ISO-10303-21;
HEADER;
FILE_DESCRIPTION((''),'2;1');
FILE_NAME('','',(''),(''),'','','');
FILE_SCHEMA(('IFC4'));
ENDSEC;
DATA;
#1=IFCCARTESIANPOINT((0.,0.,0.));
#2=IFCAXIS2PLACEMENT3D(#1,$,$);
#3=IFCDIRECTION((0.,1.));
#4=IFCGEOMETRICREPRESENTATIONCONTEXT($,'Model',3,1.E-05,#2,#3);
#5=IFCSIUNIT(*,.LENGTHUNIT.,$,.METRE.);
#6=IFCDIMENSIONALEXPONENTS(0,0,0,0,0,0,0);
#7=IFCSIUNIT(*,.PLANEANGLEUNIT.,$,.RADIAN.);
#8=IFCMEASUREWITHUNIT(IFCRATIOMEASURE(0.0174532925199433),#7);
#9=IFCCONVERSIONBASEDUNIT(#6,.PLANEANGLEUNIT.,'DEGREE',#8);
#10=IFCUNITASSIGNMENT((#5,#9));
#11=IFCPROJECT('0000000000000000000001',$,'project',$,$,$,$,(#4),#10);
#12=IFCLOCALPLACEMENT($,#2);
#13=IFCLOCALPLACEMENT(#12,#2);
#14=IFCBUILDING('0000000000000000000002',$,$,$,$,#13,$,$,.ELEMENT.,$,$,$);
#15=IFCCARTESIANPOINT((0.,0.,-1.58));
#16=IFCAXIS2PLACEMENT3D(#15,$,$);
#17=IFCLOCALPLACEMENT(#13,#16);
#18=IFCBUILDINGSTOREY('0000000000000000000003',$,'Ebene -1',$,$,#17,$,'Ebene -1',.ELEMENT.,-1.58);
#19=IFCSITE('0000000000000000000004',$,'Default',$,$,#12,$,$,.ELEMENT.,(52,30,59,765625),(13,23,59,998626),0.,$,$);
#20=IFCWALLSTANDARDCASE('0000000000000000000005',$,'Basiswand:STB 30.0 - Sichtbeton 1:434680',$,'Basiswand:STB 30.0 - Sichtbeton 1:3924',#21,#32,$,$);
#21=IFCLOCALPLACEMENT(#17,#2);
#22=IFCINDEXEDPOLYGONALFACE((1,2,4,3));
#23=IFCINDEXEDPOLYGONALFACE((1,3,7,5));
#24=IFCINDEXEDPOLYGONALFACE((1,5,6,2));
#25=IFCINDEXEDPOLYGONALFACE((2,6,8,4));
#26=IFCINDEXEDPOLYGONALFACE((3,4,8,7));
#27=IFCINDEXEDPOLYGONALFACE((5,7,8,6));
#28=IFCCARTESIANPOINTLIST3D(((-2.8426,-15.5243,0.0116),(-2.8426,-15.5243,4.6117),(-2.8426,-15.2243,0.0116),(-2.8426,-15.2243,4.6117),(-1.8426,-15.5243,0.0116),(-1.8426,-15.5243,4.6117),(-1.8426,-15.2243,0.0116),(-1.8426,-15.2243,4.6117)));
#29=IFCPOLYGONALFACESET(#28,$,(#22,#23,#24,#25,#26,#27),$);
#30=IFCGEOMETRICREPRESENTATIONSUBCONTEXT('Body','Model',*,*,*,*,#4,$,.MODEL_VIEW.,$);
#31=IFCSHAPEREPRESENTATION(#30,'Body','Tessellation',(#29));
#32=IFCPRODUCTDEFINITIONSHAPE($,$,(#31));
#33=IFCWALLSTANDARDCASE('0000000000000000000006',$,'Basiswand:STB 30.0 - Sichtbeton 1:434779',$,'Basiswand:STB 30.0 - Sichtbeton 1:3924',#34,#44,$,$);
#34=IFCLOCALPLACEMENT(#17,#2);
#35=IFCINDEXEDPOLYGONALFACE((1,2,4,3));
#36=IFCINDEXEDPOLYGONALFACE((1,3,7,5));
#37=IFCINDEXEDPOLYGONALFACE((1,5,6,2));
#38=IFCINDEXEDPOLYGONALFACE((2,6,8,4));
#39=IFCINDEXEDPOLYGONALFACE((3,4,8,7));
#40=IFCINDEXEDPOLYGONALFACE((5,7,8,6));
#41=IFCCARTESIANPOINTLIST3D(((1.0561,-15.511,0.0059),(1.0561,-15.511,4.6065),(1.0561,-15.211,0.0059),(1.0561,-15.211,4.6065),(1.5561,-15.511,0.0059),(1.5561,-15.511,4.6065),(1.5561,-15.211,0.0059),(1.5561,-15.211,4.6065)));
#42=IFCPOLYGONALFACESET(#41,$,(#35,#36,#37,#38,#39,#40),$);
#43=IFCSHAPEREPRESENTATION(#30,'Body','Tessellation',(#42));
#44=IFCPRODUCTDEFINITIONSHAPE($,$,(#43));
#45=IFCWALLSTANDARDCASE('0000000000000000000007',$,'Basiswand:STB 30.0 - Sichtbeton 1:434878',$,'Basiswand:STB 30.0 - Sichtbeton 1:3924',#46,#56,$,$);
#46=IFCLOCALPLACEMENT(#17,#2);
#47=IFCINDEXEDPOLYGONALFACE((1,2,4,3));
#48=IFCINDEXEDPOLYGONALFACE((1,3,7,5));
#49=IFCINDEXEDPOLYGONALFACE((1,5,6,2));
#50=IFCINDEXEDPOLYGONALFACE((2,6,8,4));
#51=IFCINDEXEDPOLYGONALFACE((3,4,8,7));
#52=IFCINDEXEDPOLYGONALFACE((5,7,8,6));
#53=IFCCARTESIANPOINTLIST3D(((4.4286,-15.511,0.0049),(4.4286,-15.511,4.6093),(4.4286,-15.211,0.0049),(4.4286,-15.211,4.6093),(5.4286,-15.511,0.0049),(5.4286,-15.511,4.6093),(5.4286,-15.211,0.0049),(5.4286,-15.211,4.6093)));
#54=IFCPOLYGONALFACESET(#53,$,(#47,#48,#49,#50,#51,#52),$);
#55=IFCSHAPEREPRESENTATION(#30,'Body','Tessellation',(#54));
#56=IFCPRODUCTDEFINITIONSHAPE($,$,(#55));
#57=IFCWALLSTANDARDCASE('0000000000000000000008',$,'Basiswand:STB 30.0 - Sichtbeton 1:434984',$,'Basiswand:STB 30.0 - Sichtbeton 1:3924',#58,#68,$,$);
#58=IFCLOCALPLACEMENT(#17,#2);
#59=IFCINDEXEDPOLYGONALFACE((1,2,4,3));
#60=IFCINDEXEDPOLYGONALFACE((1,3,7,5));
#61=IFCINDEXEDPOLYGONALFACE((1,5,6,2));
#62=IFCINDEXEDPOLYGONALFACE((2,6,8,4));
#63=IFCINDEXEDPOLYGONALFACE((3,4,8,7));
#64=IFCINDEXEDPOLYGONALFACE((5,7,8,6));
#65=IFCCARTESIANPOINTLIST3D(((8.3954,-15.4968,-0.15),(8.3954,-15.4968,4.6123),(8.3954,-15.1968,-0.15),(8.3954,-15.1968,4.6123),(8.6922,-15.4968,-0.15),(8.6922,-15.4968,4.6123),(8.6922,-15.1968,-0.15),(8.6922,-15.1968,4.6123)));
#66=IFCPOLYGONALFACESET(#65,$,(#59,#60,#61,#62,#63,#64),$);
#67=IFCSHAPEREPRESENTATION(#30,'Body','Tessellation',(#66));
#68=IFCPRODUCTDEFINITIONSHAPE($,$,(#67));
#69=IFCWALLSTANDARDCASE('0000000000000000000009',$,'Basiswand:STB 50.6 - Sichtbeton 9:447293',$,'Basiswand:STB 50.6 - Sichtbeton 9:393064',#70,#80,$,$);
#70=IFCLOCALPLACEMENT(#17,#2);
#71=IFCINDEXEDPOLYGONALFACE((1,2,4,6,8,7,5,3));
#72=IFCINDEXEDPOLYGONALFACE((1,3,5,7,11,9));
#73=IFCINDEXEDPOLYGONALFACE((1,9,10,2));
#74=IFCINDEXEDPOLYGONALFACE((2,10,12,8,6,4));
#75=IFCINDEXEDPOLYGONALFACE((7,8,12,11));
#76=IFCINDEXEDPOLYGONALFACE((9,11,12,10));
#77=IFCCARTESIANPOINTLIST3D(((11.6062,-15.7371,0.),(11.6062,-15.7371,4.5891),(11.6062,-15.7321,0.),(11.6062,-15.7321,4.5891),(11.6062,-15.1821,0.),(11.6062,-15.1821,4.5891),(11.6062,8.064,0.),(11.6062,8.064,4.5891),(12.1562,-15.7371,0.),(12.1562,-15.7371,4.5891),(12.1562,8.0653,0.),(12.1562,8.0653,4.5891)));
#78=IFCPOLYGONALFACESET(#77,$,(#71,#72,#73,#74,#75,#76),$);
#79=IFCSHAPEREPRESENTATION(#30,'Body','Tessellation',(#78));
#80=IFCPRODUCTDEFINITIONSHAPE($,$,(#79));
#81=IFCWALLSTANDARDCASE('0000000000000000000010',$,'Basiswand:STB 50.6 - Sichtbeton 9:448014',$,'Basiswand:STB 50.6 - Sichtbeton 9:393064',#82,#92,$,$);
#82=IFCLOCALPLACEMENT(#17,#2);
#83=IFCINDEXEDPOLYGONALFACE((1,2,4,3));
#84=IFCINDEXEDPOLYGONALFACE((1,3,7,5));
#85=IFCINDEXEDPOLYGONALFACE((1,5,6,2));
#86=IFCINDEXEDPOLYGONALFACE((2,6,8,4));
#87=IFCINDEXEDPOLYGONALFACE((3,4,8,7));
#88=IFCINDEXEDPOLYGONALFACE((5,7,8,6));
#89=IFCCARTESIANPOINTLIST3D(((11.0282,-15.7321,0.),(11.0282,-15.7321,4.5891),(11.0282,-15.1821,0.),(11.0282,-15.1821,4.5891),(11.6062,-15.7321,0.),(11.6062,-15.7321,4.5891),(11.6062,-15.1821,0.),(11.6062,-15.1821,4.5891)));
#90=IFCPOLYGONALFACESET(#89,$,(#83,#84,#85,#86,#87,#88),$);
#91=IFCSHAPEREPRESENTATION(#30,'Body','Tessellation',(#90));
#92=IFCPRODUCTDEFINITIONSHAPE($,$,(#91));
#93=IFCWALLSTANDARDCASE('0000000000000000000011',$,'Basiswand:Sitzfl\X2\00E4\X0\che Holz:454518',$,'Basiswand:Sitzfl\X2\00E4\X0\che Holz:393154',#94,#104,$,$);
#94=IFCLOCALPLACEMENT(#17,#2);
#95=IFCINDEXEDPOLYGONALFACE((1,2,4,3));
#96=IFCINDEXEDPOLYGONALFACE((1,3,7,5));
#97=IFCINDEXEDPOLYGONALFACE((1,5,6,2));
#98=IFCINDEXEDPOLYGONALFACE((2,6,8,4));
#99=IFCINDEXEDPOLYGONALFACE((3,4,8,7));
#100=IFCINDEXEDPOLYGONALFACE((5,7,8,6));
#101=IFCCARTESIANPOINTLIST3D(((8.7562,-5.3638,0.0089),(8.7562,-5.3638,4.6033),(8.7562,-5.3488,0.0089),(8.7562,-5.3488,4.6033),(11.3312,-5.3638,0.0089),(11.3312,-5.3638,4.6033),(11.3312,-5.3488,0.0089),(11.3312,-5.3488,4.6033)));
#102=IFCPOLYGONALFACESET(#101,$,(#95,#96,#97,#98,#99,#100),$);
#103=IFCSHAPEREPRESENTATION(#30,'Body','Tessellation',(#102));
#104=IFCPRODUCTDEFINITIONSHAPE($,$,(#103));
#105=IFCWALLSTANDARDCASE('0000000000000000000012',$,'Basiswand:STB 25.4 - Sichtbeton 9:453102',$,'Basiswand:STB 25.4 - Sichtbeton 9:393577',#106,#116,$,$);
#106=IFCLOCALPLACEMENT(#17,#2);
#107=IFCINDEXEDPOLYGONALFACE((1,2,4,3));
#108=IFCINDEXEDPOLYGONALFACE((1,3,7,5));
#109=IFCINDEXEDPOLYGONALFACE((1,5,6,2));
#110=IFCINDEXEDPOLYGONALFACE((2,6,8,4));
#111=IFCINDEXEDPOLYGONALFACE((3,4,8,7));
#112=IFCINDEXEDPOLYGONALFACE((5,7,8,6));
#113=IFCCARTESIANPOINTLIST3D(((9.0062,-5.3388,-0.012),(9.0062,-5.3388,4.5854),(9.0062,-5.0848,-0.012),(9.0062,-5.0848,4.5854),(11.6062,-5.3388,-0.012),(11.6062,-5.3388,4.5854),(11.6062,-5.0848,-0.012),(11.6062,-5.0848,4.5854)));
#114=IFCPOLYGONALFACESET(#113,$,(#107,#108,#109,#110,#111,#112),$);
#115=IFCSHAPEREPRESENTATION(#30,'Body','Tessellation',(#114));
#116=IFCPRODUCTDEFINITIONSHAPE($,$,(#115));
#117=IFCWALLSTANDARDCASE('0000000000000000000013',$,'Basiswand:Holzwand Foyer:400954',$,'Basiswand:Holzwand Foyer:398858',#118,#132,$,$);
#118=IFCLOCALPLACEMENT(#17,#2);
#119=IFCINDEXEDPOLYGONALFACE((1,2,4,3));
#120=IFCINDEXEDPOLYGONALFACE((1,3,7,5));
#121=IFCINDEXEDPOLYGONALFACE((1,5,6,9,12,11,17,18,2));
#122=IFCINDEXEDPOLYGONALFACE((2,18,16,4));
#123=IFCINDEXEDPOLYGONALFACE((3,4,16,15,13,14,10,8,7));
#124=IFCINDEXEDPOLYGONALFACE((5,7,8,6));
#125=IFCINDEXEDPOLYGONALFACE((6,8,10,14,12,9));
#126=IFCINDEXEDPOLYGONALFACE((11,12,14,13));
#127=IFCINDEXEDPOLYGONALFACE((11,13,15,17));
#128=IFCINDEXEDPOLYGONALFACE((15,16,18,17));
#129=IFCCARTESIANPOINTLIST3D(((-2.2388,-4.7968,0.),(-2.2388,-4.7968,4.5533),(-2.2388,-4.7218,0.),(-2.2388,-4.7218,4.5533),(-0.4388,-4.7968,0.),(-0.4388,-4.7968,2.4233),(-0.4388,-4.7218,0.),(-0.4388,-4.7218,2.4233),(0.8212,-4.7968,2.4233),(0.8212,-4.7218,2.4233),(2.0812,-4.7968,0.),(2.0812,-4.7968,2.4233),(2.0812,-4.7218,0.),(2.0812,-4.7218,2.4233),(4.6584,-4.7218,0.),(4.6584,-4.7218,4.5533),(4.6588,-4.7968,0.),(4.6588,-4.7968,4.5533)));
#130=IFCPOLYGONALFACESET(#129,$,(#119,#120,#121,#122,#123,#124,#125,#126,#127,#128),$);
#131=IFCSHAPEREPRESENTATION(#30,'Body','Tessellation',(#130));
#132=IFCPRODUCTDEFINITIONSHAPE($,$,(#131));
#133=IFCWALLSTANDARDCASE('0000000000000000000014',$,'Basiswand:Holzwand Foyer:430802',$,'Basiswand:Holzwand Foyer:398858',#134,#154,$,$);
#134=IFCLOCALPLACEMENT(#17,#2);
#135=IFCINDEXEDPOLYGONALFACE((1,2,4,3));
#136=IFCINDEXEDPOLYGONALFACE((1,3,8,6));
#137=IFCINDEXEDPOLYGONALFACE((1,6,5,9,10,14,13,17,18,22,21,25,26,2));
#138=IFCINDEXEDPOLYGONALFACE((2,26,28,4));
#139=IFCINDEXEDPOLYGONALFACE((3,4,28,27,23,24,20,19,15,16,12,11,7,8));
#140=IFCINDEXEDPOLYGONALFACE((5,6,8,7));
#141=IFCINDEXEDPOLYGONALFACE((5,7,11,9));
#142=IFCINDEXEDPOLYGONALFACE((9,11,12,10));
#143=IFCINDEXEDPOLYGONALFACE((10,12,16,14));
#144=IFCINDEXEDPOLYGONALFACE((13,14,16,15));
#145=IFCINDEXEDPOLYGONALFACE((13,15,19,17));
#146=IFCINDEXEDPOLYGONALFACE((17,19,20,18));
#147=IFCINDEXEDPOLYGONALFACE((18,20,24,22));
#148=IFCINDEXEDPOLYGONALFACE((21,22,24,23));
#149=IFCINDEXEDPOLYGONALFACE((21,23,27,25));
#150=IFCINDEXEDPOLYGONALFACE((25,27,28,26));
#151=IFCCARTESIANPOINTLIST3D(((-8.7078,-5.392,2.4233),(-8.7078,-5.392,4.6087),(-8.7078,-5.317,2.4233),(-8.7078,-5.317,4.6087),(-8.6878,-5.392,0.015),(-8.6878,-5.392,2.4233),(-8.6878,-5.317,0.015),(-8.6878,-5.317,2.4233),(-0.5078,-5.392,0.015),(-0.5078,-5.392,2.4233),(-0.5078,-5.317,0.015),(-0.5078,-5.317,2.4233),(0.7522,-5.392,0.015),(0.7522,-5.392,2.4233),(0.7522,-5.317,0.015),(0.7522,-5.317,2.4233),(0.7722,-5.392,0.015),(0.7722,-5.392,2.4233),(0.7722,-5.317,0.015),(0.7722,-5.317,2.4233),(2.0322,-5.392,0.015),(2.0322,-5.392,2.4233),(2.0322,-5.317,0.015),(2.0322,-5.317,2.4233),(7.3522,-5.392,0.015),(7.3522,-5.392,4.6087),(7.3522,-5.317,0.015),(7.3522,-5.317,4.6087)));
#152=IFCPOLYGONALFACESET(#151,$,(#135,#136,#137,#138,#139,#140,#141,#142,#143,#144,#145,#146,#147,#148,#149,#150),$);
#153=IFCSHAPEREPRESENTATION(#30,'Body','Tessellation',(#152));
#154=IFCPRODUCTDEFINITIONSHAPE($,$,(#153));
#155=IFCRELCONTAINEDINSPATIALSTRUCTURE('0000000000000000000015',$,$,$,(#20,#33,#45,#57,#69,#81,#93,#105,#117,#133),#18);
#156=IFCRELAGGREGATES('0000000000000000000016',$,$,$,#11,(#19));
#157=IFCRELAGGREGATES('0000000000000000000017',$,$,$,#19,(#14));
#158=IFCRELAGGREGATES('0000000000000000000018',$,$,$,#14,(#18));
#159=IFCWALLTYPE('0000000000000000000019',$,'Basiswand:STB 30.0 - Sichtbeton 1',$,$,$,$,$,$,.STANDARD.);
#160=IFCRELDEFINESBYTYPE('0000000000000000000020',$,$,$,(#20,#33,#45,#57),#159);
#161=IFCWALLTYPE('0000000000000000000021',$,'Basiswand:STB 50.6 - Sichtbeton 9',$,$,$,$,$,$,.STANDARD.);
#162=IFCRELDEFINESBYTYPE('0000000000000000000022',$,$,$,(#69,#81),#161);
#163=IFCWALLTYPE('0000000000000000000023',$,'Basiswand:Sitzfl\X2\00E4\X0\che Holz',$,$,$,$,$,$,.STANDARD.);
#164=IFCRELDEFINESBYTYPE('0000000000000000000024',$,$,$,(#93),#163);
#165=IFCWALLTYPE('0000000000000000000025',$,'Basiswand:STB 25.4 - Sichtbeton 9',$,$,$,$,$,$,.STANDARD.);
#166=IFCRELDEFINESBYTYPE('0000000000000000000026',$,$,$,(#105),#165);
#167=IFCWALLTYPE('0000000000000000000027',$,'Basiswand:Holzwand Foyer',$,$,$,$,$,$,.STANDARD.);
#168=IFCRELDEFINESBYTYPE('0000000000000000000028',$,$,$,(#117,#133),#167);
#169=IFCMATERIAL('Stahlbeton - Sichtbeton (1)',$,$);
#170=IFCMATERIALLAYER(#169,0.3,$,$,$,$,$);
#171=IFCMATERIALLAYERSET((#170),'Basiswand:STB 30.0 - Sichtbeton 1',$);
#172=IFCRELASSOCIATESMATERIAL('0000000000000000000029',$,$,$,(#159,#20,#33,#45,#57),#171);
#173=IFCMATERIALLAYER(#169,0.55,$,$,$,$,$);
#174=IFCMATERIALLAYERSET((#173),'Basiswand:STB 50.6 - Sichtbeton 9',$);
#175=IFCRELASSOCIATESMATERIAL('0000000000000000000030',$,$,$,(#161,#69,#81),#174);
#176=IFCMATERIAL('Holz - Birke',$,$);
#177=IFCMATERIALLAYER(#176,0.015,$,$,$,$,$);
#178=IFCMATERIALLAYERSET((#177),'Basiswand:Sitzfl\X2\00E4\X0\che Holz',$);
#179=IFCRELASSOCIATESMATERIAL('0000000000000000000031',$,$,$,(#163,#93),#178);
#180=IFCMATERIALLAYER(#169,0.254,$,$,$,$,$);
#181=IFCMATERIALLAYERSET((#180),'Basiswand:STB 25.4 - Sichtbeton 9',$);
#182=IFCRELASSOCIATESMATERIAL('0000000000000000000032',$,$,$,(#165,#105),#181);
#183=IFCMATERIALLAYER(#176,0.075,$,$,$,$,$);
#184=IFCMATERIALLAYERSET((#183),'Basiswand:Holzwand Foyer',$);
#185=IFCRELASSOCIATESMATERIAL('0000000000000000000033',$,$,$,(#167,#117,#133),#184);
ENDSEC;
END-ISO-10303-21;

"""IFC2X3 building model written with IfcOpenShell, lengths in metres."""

from ifc_helpers import new_model, entity, si_unit, converted_unit, direction, frame, frame_2d, origin, place, context, subcontext, project, spatial, polyline, rectangle, outline, extrude, material, layer, layer_set, layer_usage, type_object, element, save


model = new_model("IFC2X3")

# Units and contexts
model_context = context("Model", 3, precision=1e-05, world=origin(), true_north=direction((0.0, 1.0)))
body_context = subcontext(model_context, "Body", "Model", "MODEL_VIEW")
ifc_project = project(units=[si_unit("LENGTHUNIT", "METRE"), converted_unit("PLANEANGLEUNIT", "DEGREE", entity("IfcRatioMeasure", 0.0174532925199433), si_unit("PLANEANGLEUNIT", "RADIAN"), dimensions=[0, 0, 0, 0, 0, 0, 0])], contexts=[model_context])

# Site, building, storey
site_placement = place(None, origin())
site = spatial("IfcSite", under=ifc_project, at=site_placement, Name="Default", CompositionType="ELEMENT", RefLatitude=(52, 30, 59, 765625), RefLongitude=(13, 23, 59, 998626), RefElevation=0.0)
building_placement = place(site_placement, origin())
building = spatial("IfcBuilding", under=site, at=building_placement, CompositionType="ELEMENT")
storey_placement = place(building_placement, frame((0.0, 0.0, -1.58)))
storey = spatial("IfcBuildingStorey", under=building, at=storey_placement, Name="Ebene -1", LongName="Ebene -1", CompositionType="ELEMENT", Elevation=-1.58)

# Walls
ifc_material_1 = material(Name="Stahlbeton - Sichtbeton (1)")
ifc_layer_1 = layer(ifc_material_1, 0.3)
ifc_layer_set_1 = layer_set([ifc_layer_1], Name="Basiswand:STB 30.0 - Sichtbeton 1")
ifc_layer_usage_1 = layer_usage(ifc_layer_set_1, "AXIS2", "NEGATIVE", 0.15)
wall_type_1 = type_object("IfcWallType", Name="Basiswand:STB 30.0 - Sichtbeton 1", PredefinedType="STANDARD", material=ifc_layer_set_1)
wall_1_placement = place(storey_placement, frame((-2.8426, -15.3743, 0.0116)))
element("IfcWallStandardCase", 1, at=wall_1_placement, inside=storey, type_object=wall_type_1, material=ifc_layer_usage_1, Name="Basiswand:STB 30.0 - Sichtbeton 1:434680", ObjectType="Basiswand:STB 30.0 - Sichtbeton 1:3924", context=body_context, shape_type="SweptSolid", body=[
    extrude(rectangle(XDim=1.0, YDim=0.3, at=frame_2d((0.5, 0.0), x_axis=(-1.0, 0.0))), origin(), (0.0, 0.0, 1.0), 4.6002),
])
ifc_layer_usage_2 = layer_usage(ifc_layer_set_1, "AXIS2", "NEGATIVE", 0.15)
wall_2_placement = place(storey_placement, frame((1.0561, -15.361, 0.0059)))
element("IfcWallStandardCase", 2, at=wall_2_placement, inside=storey, type_object=wall_type_1, material=ifc_layer_usage_2, Name="Basiswand:STB 30.0 - Sichtbeton 1:434779", ObjectType="Basiswand:STB 30.0 - Sichtbeton 1:3924", context=body_context, shape_type="SweptSolid", body=[
    extrude(rectangle(XDim=0.5, YDim=0.3, at=frame_2d((0.25, 0.0), x_axis=(-1.0, 0.0))), origin(), (0.0, 0.0, 1.0), 4.6006),
])
ifc_layer_usage_3 = layer_usage(ifc_layer_set_1, "AXIS2", "NEGATIVE", 0.15)
wall_3_placement = place(storey_placement, frame((4.4286, -15.361, 0.0049)))
element("IfcWallStandardCase", 3, at=wall_3_placement, inside=storey, type_object=wall_type_1, material=ifc_layer_usage_3, Name="Basiswand:STB 30.0 - Sichtbeton 1:434878", ObjectType="Basiswand:STB 30.0 - Sichtbeton 1:3924", context=body_context, shape_type="SweptSolid", body=[
    extrude(rectangle(XDim=1.0, YDim=0.3, at=frame_2d((0.5, 0.0), x_axis=(-1.0, 0.0))), origin(), (0.0, 0.0, 1.0), 4.6044),
])
ifc_layer_usage_4 = layer_usage(ifc_layer_set_1, "AXIS2", "NEGATIVE", 0.15)
wall_4_placement = place(storey_placement, frame((8.3954, -15.3468, -0.15)))
element("IfcWallStandardCase", 4, at=wall_4_placement, inside=storey, type_object=wall_type_1, material=ifc_layer_usage_4, Name="Basiswand:STB 30.0 - Sichtbeton 1:434984", ObjectType="Basiswand:STB 30.0 - Sichtbeton 1:3924", context=body_context, shape_type="SweptSolid", body=[
    extrude(rectangle(XDim=0.2968, YDim=0.3, at=frame_2d((0.1484, 0.0), x_axis=(-1.0, 0.0))), origin(), (0.0, 0.0, 1.0), 4.7623),
])
ifc_layer_2 = layer(ifc_material_1, 0.55)
ifc_layer_set_2 = layer_set([ifc_layer_2], Name="Basiswand:STB 50.6 - Sichtbeton 9")
ifc_layer_usage_5 = layer_usage(ifc_layer_set_2, "AXIS2", "NEGATIVE", 0.275)
wall_type_2 = type_object("IfcWallType", Name="Basiswand:STB 50.6 - Sichtbeton 9", PredefinedType="STANDARD", material=ifc_layer_set_2)
wall_5_placement = place(storey_placement, frame((11.8812, -15.7371, 0.0), z_axis=(0.0, 0.0, 1.0), x_axis=(0.0, 1.0, 0.0)))
element("IfcWallStandardCase", 5, at=wall_5_placement, inside=storey, type_object=wall_type_2, material=ifc_layer_usage_5, Name="Basiswand:STB 50.6 - Sichtbeton 9:447293", ObjectType="Basiswand:STB 50.6 - Sichtbeton 9:393064", context=body_context, shape_type="SweptSolid", body=[
    extrude(outline(polyline([(23.8024, -0.275), (23.801, 0.275), (0.555, 0.275), (0.005, 0.275), (0.0, 0.275), (0.0, -0.275), (23.8024, -0.275)])), origin(), (0.0, 0.0, 1.0), 4.5891),
])
ifc_layer_usage_6 = layer_usage(ifc_layer_set_2, "AXIS2", "NEGATIVE", 0.275)
wall_6_placement = place(storey_placement, frame((11.0282, -15.4571, 0.0)))
element("IfcWallStandardCase", 6, at=wall_6_placement, inside=storey, type_object=wall_type_2, material=ifc_layer_usage_6, Name="Basiswand:STB 50.6 - Sichtbeton 9:448014", ObjectType="Basiswand:STB 50.6 - Sichtbeton 9:393064", context=body_context, shape_type="SweptSolid", body=[
    extrude(rectangle(XDim=0.578, YDim=0.55, at=frame_2d((0.289, 0.0), x_axis=(-1.0, 0.0))), origin(), (0.0, 0.0, 1.0), 4.5891),
])
ifc_material_2 = material(Name="Holz - Birke")
ifc_layer_3 = layer(ifc_material_2, 0.015)
ifc_layer_set_3 = layer_set([ifc_layer_3], Name="Basiswand:Sitzfläche Holz")
ifc_layer_usage_7 = layer_usage(ifc_layer_set_3, "AXIS2", "POSITIVE", -0.0075)
wall_type_3 = type_object("IfcWallType", Name="Basiswand:Sitzfläche Holz", PredefinedType="STANDARD", material=ifc_layer_set_3)
wall_7_placement = place(storey_placement, frame((11.3312, -5.3563, 0.0089), z_axis=(0.0, 0.0, 1.0), x_axis=(-1.0, 0.0, 0.0)))
element("IfcWallStandardCase", 7, at=wall_7_placement, inside=storey, type_object=wall_type_3, material=ifc_layer_usage_7, Name="Basiswand:Sitzfläche Holz:454518", ObjectType="Basiswand:Sitzfläche Holz:393154", context=body_context, shape_type="SweptSolid", body=[
    extrude(rectangle(XDim=2.575, YDim=0.015, at=frame_2d((1.2875, 0.0), x_axis=(-1.0, 0.0))), origin(), (0.0, 0.0, 1.0), 4.5944),
])
ifc_layer_4 = layer(ifc_material_1, 0.254)
ifc_layer_set_4 = layer_set([ifc_layer_4], Name="Basiswand:STB 25.4 - Sichtbeton 9")
ifc_layer_usage_8 = layer_usage(ifc_layer_set_4, "AXIS2", "NEGATIVE", 0.127)
wall_type_4 = type_object("IfcWallType", Name="Basiswand:STB 25.4 - Sichtbeton 9", PredefinedType="STANDARD", material=ifc_layer_set_4)
wall_8_placement = place(storey_placement, frame((11.6062, -5.2118, -0.012), z_axis=(0.0, 0.0, 1.0), x_axis=(-1.0, 0.0, 0.0)))
element("IfcWallStandardCase", 8, at=wall_8_placement, inside=storey, type_object=wall_type_4, material=ifc_layer_usage_8, Name="Basiswand:STB 25.4 - Sichtbeton 9:453102", ObjectType="Basiswand:STB 25.4 - Sichtbeton 9:393577", context=body_context, shape_type="SweptSolid", body=[
    extrude(rectangle(XDim=2.6, YDim=0.254, at=frame_2d((1.3, 0.0), x_axis=(-1.0, 0.0))), origin(), (0.0, 0.0, 1.0), 4.5974),
])

# Walls, openings
ifc_layer_5 = layer(ifc_material_2, 0.075)
ifc_layer_set_5 = layer_set([ifc_layer_5], Name="Basiswand:Holzwand Foyer")
ifc_layer_usage_9 = layer_usage(ifc_layer_set_5, "AXIS2", "NEGATIVE", 0.0375)
wall_type_5 = type_object("IfcWallType", Name="Basiswand:Holzwand Foyer", PredefinedType="STANDARD", material=ifc_layer_set_5)
wall_9_placement = place(storey_placement, frame((-2.2388, -4.7593, 0.0)))
wall_9 = element("IfcWallStandardCase", 9, at=wall_9_placement, inside=storey, type_object=wall_type_5, material=ifc_layer_usage_9, Name="Basiswand:Holzwand Foyer:400954", ObjectType="Basiswand:Holzwand Foyer:398858", context=body_context, shape_type="SweptSolid", body=[
    extrude(outline(polyline([(0.0, -0.0375), (6.8975, -0.0375), (6.8972, 0.0375), (0.0, 0.0375), (0.0, -0.0375)])), origin(), (0.0, 0.0, 1.0), 4.5533),
])
opening_1_placement = place(wall_9_placement, frame((3.06, 0.0375, 0.0)))
element("IfcOpeningElement", 10, at=opening_1_placement, cuts=wall_9, ObjectType="Opening", context=body_context, shape_type="SweptSolid", body=[
    extrude(rectangle(XDim=2.4233, YDim=1.26, at=frame_2d((1.2116, 0.63), x_axis=(1.0, 0.0))), frame((0.0, 0.0, 0.0), z_axis=(0.0, -1.0, 0.0), x_axis=(0.0, 0.0, 1.0)), (0.0, 0.0, 1.0), 0.075),
])
opening_2_placement = place(wall_9_placement, frame((3.06, -0.0375, 0.0)))
element("IfcOpeningElement", 11, at=opening_2_placement, cuts=wall_9, ObjectType="Opening", context=body_context, shape_type="SweptSolid", body=[
    extrude(rectangle(XDim=2.4233, YDim=1.26, at=frame_2d((1.2116, 0.63), x_axis=(1.0, 0.0))), frame((0.0, 0.0, 0.0), z_axis=(0.0, 1.0, 0.0), x_axis=(0.0, 0.0, 1.0)), (0.0, 0.0, 1.0), 0.075),
])
ifc_layer_usage_10 = layer_usage(ifc_layer_set_5, "AXIS2", "NEGATIVE", 0.0375)
wall_10_placement = place(storey_placement, frame((7.3522, -5.3545, 0.015), z_axis=(0.0, 0.0, 1.0), x_axis=(-1.0, 0.0, 0.0)))
wall_10 = element("IfcWallStandardCase", 12, at=wall_10_placement, inside=storey, type_object=wall_type_5, material=ifc_layer_usage_10, Name="Basiswand:Holzwand Foyer:430802", ObjectType="Basiswand:Holzwand Foyer:398858", context=body_context, shape_type="SweptSolid", body=[
    extrude(rectangle(XDim=16.06, YDim=0.075, at=frame_2d((8.03, 0.0), x_axis=(-1.0, 0.0))), origin(), (0.0, 0.0, 1.0), 4.5937),
])
opening_3_placement = place(wall_10_placement, frame((16.04, -0.0375, -0.015)))
element("IfcOpeningElement", 13, at=opening_3_placement, cuts=wall_10, ObjectType="Opening", context=body_context, shape_type="SweptSolid", body=[
    extrude(rectangle(XDim=2.4233, YDim=1.26, at=frame_2d((1.2116, 0.63), x_axis=(1.0, 0.0))), frame((0.0, 0.0, 0.0), z_axis=(0.0, 1.0, 0.0), x_axis=(0.0, 0.0, 1.0)), (0.0, 0.0, 1.0), 0.075),
])
opening_4_placement = place(wall_10_placement, frame((6.6, -0.0375, -0.015)))
element("IfcOpeningElement", 14, at=opening_4_placement, cuts=wall_10, ObjectType="Opening", context=body_context, shape_type="SweptSolid", body=[
    extrude(rectangle(XDim=2.4233, YDim=1.26, at=frame_2d((1.2116, 0.63), x_axis=(1.0, 0.0))), frame((0.0, 0.0, 0.0), z_axis=(0.0, 1.0, 0.0), x_axis=(0.0, 0.0, 1.0)), (0.0, 0.0, 1.0), 0.075),
])
opening_5_placement = place(wall_10_placement, frame((5.32, -0.0375, -0.015)))
element("IfcOpeningElement", 15, at=opening_5_placement, cuts=wall_10, ObjectType="Opening", context=body_context, shape_type="SweptSolid", body=[
    extrude(rectangle(XDim=2.4233, YDim=1.26, at=frame_2d((1.2116, 0.63), x_axis=(1.0, 0.0))), frame((0.0, 0.0, 0.0), z_axis=(0.0, 1.0, 0.0), x_axis=(0.0, 0.0, 1.0)), (0.0, 0.0, 1.0), 0.075),
])

save(model, "model.ifc")
